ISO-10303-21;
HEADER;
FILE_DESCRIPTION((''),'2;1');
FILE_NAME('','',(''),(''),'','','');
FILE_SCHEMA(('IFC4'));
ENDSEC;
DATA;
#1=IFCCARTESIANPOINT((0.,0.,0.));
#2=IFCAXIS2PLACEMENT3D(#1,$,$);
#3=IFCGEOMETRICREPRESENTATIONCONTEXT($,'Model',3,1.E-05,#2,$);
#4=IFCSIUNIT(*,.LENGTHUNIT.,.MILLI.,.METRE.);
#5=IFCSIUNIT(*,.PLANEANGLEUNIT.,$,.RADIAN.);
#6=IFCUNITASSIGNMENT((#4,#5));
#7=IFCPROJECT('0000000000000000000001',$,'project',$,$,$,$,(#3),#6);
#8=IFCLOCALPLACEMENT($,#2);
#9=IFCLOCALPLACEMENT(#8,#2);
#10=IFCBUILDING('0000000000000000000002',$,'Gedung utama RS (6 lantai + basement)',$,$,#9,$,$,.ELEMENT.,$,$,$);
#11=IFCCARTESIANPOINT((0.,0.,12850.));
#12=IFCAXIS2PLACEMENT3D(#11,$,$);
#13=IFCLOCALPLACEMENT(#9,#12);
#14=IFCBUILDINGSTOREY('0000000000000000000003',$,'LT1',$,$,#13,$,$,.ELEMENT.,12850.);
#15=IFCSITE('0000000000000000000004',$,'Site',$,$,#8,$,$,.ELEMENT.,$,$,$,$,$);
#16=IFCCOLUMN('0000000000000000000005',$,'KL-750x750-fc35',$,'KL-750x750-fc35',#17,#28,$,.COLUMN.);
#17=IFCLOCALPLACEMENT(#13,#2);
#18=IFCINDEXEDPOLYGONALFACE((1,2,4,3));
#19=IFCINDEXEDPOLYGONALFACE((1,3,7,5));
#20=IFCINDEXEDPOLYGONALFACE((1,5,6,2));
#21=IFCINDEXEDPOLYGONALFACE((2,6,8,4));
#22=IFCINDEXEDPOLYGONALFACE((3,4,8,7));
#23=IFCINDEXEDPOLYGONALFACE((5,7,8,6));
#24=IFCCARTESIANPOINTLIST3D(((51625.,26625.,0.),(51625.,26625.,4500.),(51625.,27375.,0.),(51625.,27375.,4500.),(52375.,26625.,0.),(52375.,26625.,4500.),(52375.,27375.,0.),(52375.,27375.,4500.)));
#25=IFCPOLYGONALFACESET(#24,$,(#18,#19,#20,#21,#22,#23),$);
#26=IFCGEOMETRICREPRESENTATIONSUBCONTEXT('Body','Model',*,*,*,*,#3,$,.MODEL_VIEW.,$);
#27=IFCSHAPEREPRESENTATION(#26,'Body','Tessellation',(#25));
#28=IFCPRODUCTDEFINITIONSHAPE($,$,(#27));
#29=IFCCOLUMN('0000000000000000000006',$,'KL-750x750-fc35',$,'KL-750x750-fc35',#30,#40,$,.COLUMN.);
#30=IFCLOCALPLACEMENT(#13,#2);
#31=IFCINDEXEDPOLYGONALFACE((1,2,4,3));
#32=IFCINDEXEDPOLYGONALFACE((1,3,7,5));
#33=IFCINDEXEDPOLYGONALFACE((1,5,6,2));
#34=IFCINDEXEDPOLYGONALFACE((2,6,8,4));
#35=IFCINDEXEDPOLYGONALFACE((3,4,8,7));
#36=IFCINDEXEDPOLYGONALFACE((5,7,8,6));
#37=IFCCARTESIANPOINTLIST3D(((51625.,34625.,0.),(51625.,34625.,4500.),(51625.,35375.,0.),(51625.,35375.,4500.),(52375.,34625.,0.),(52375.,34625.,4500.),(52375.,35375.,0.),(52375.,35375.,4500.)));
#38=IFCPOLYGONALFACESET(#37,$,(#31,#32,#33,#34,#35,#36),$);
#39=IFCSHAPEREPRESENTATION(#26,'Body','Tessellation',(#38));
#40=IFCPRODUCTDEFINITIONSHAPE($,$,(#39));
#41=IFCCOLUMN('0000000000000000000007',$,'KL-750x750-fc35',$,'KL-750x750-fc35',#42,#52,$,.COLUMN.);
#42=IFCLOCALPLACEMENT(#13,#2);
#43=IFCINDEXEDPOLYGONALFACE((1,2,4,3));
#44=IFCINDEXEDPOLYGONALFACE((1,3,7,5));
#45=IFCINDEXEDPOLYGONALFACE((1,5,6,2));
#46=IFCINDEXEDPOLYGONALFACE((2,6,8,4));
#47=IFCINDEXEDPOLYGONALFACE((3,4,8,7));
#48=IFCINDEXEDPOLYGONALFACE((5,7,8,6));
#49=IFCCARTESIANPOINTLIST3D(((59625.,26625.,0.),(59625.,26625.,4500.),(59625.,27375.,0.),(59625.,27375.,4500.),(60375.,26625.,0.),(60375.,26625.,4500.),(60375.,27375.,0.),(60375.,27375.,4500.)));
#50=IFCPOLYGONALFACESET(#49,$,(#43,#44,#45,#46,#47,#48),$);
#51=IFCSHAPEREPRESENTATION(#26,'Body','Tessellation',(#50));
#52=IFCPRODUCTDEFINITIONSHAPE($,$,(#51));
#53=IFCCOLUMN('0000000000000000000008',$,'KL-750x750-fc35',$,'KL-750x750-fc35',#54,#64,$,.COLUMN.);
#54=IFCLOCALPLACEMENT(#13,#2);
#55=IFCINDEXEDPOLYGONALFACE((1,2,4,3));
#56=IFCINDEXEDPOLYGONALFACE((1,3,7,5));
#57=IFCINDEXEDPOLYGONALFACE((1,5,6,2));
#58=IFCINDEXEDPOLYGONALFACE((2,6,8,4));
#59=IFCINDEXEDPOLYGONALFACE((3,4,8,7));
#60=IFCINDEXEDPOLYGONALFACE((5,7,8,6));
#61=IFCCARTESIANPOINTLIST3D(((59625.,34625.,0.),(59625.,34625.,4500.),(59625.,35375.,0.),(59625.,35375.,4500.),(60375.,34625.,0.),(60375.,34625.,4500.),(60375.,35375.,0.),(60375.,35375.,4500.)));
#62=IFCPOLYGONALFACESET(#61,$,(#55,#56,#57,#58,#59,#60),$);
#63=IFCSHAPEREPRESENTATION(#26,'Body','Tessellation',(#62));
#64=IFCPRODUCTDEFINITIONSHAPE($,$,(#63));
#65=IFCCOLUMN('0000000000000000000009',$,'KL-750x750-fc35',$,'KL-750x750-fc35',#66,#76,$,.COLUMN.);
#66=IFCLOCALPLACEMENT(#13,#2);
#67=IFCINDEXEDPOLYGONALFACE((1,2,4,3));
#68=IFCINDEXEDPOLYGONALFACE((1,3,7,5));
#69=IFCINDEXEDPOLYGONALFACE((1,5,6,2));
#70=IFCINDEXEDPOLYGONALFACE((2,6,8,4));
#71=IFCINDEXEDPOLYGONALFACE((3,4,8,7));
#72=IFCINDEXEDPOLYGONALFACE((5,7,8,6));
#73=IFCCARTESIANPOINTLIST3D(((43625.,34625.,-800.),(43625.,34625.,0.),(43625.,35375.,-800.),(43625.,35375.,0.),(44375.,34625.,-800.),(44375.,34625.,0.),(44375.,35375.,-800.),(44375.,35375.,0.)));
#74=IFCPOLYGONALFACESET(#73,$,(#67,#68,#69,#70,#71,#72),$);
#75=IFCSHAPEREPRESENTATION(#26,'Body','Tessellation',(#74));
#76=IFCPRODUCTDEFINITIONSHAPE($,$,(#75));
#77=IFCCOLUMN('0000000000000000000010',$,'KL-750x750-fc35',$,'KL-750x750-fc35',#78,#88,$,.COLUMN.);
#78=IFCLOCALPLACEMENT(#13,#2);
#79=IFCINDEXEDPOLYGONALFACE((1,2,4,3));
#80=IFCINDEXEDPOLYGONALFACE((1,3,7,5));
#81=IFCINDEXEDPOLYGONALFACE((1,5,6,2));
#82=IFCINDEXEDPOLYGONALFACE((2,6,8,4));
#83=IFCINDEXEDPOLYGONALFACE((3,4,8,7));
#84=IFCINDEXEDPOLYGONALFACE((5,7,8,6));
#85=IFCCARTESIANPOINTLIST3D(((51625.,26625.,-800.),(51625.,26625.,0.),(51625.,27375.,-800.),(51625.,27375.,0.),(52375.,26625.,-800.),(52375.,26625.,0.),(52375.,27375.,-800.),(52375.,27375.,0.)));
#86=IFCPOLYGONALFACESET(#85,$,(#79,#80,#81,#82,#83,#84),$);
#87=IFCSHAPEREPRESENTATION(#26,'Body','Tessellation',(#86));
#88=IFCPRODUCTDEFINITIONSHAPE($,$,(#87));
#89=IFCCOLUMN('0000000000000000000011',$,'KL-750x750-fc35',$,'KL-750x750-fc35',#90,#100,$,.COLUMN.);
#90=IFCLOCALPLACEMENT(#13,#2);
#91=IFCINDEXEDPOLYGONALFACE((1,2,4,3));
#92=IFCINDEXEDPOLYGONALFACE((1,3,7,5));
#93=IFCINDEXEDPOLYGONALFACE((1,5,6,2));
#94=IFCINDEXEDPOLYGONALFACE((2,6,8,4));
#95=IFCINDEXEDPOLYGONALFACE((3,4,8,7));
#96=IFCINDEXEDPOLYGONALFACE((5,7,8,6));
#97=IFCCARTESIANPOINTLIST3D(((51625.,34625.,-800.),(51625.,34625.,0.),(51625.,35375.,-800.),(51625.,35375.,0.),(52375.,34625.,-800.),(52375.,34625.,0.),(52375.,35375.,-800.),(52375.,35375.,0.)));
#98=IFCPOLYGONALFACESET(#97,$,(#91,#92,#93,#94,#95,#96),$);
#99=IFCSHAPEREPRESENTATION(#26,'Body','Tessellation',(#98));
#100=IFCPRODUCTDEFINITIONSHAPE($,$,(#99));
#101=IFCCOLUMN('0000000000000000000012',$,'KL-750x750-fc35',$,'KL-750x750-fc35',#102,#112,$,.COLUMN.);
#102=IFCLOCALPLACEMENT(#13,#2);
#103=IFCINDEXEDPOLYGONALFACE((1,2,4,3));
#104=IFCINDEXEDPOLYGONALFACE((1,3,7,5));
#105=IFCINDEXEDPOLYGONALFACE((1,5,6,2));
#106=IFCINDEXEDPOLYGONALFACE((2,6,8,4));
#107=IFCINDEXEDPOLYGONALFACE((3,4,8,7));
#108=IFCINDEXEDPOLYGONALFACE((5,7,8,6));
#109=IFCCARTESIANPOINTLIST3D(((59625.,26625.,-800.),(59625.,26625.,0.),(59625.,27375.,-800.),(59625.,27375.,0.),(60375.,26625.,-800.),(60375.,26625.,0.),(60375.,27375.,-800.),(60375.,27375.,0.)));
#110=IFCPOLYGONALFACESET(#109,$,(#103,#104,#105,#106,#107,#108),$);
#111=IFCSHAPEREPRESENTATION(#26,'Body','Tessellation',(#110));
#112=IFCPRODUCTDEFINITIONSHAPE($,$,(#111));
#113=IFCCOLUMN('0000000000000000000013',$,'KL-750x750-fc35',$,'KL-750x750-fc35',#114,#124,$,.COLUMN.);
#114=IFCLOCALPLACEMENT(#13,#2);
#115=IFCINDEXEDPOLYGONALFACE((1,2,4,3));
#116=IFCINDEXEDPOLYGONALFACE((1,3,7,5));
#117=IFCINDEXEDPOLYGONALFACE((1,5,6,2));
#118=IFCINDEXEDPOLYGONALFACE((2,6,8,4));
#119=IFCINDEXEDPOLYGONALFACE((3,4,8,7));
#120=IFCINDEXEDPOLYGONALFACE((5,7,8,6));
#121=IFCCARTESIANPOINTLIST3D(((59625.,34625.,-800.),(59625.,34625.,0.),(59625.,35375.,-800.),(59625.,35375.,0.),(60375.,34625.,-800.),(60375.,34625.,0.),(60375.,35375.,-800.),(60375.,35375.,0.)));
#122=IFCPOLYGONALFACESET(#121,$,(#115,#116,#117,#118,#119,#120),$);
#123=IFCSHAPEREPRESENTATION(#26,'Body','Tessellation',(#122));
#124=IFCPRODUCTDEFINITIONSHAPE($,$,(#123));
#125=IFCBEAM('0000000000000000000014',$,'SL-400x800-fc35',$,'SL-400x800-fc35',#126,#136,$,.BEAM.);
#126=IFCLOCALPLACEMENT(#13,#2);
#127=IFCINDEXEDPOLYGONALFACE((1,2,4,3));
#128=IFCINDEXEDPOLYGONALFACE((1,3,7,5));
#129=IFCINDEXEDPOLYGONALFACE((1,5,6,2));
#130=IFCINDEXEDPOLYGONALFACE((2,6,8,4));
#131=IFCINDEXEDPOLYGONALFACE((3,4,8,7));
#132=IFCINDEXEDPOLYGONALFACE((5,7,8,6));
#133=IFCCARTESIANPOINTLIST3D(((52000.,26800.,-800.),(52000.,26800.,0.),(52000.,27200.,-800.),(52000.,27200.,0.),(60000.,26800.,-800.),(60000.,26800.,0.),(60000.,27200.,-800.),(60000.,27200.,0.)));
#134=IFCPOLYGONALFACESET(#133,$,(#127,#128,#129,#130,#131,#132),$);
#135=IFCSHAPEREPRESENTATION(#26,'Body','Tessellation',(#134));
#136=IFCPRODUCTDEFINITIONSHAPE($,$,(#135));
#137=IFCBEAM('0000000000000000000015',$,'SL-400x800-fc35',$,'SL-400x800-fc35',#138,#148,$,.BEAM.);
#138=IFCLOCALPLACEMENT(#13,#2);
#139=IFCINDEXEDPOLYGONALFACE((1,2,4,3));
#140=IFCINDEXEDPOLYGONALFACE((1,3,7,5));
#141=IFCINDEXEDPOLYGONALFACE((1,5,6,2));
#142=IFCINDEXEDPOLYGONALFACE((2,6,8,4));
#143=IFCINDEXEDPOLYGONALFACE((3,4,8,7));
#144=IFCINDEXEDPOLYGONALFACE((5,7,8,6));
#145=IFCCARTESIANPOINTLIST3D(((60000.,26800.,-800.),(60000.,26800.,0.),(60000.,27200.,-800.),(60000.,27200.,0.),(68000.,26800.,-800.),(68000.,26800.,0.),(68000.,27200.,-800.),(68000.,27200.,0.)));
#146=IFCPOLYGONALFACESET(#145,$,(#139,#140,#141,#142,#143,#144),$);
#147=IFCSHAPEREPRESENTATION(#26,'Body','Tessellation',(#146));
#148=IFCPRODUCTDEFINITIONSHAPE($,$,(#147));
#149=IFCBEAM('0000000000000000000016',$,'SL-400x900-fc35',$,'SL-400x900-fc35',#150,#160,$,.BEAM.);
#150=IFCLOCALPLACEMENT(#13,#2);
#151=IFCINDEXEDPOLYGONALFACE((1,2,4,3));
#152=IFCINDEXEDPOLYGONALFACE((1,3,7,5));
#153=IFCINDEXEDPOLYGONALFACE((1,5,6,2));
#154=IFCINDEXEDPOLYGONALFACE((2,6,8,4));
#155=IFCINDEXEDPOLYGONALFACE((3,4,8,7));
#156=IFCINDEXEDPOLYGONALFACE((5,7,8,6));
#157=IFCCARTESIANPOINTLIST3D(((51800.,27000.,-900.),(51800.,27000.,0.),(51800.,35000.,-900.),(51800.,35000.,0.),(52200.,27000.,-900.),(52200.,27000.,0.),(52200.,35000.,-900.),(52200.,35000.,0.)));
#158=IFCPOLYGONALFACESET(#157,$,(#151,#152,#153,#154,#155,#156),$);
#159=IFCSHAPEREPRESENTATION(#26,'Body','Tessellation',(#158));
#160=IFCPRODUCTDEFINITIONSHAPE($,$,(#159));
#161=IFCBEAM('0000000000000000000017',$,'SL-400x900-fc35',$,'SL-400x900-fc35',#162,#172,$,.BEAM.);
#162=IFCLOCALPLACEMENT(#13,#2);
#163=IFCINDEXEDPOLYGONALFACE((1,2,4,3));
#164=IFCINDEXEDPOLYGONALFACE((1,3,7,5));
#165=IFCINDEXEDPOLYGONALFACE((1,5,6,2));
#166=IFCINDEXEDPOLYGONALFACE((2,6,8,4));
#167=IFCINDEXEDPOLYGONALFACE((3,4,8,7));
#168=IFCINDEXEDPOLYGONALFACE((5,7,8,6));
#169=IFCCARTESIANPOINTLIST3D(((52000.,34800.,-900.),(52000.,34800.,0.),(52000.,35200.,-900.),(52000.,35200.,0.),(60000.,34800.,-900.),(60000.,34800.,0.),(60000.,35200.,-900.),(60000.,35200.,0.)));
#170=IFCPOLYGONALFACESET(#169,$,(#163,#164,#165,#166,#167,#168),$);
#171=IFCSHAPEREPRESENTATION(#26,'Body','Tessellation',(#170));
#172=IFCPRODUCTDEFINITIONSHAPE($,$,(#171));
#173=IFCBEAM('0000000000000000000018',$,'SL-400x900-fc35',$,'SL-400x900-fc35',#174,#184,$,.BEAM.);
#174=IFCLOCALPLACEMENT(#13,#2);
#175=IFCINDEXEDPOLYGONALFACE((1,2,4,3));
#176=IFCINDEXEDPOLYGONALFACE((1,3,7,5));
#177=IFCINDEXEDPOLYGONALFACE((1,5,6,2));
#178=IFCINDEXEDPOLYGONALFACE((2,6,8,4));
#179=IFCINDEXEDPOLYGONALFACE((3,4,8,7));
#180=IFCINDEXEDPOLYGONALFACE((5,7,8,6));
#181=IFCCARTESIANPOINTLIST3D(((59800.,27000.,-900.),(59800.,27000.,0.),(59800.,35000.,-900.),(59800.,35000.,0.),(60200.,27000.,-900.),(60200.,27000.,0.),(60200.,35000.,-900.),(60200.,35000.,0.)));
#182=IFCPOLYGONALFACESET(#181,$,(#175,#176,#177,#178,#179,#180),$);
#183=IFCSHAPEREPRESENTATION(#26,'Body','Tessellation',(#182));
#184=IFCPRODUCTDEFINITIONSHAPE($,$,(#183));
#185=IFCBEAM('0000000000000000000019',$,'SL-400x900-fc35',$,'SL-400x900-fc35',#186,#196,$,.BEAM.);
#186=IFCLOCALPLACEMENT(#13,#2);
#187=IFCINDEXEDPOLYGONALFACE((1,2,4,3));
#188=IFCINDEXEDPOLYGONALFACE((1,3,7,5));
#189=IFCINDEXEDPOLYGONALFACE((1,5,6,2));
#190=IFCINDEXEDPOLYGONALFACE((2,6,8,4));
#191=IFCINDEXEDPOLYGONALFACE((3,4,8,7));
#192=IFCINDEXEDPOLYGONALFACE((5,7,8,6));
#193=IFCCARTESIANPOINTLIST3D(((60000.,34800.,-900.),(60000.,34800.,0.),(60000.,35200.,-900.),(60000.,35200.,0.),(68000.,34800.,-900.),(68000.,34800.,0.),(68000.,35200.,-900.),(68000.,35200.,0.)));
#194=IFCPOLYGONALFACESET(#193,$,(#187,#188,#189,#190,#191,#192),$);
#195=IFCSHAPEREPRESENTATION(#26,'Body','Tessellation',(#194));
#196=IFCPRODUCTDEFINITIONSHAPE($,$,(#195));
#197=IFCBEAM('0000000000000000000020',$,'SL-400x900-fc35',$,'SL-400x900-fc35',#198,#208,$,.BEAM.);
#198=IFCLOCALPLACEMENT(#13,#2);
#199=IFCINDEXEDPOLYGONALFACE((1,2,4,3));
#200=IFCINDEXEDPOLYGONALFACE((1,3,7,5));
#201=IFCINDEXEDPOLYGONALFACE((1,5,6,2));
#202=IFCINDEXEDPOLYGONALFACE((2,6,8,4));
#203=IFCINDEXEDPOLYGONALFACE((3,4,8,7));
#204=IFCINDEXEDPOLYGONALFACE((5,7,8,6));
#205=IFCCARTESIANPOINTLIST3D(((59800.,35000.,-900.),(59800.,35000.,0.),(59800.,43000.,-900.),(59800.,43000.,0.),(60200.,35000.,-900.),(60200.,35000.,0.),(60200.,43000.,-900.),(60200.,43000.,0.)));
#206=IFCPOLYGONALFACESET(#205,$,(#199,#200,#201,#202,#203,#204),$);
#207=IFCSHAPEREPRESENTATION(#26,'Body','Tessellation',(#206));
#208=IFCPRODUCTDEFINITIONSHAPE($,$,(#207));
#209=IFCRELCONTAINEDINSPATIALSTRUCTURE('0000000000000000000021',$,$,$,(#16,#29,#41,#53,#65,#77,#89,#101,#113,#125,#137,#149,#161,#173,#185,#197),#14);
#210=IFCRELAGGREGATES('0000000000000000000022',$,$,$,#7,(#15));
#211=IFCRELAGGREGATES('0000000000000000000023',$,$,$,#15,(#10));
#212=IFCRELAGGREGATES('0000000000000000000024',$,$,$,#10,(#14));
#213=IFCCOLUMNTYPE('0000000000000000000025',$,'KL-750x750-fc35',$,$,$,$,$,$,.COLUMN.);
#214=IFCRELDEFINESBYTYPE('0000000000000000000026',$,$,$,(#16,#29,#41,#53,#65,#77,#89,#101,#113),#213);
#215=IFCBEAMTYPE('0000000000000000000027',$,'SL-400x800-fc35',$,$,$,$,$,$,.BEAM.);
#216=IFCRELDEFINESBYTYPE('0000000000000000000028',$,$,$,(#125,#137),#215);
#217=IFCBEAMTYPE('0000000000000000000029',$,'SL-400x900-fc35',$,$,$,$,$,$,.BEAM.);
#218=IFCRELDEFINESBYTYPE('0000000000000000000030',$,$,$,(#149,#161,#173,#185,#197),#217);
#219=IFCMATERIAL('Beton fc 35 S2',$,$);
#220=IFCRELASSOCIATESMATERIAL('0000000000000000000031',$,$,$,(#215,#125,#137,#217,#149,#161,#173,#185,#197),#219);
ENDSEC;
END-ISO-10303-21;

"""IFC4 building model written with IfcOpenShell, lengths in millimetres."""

from ifc_helpers import new_model, si_unit, frame, origin, origin_2d, place, context, subcontext, project, spatial, rectangle, extrude, material, material_profile, profile_set, profile_usage, type_object, element, save


model = new_model("IFC4")

# Units and contexts
model_context = context("Model", 3, precision=1e-05, world=origin())
body_context = subcontext(model_context, "Body", "Model", "MODEL_VIEW")
ifc_project = project(units=[si_unit("LENGTHUNIT", "METRE", prefix="MILLI"), si_unit("PLANEANGLEUNIT", "RADIAN")], contexts=[model_context])

# Site, building, storey
site_placement = place(None, origin())
site = spatial("IfcSite", under=ifc_project, at=site_placement, Name="Site", CompositionType="ELEMENT")
building_placement = place(site_placement, origin())
building = spatial("IfcBuilding", under=site, at=building_placement, Name="Gedung utama RS (6 lantai + basement)", CompositionType="ELEMENT")
storey_placement = place(building_placement, frame((0.0, 0.0, 12850.0)))
storey = spatial("IfcBuildingStorey", under=building, at=storey_placement, Name="LT1", CompositionType="ELEMENT", Elevation=12850.0)

# Columns
ifc_material_profile_1 = material_profile(None, rectangle(XDim=750.0, YDim=750.0, at=origin_2d()), Name="KL-750x750-fc35")
ifc_profile_set_1 = profile_set([ifc_material_profile_1], Name="KL-750x750-fc35")
ifc_profile_usage_1 = profile_usage(ifc_profile_set_1, cardinal=5)
column_type = type_object("IfcColumnType", Name="KL-750x750-fc35", PredefinedType="COLUMN", material=ifc_profile_set_1)
for number, where, z_axis, x_axis, name in (
    (1, (52000.0, 27000.0, 0.0), (0.0, 0.0, 1.0), (1.0, 0.0, 0.0), "KL-750x750-fc35"),
    (2, (52000.0, 35000.0, 0.0), (0.0, 0.0, 1.0), (1.0, 0.0, 0.0), "KL-750x750-fc35"),
    (3, (60000.0, 27000.0, 0.0), (0.0, 0.0, 1.0), (1.0, 0.0, 0.0), "KL-750x750-fc35"),
    (4, (60000.0, 35000.0, 0.0), (0.0, 0.0, 1.0), (1.0, 0.0, 0.0), "KL-750x750-fc35"),
):
    element("IfcColumn", number, at=place(storey_placement, frame(where, z_axis=z_axis, x_axis=x_axis)), inside=storey, type_object=column_type, material=ifc_profile_usage_1, Name=name, ObjectType="KL-750x750-fc35", PredefinedType="COLUMN", context=body_context, shape_type="SweptSolid", body=[
        extrude(rectangle(XDim=750.0, YDim=750.0, at=origin_2d()), origin(), (0.0, 0.0, 1.0), 4500.0),
    ])
for number, where, z_axis, x_axis, name in (
    (5, (44000.0, 35000.0, -800.0), (0.0, 0.0, 1.0), (1.0, 0.0, 0.0), "KL-750x750-fc35"),
    (6, (52000.0, 27000.0, -800.0), (0.0, 0.0, 1.0), (1.0, 0.0, 0.0), "KL-750x750-fc35"),
    (7, (52000.0, 35000.0, -800.0), (0.0, 0.0, 1.0), (1.0, 0.0, 0.0), "KL-750x750-fc35"),
    (8, (60000.0, 27000.0, -800.0), (0.0, 0.0, 1.0), (1.0, 0.0, 0.0), "KL-750x750-fc35"),
    (9, (60000.0, 35000.0, -800.0), (0.0, 0.0, 1.0), (1.0, 0.0, 0.0), "KL-750x750-fc35"),
):
    element("IfcColumn", number, at=place(storey_placement, frame(where, z_axis=z_axis, x_axis=x_axis)), inside=storey, type_object=column_type, material=ifc_profile_usage_1, Name=name, ObjectType="KL-750x750-fc35", PredefinedType="COLUMN", context=body_context, shape_type="SweptSolid", body=[
        extrude(rectangle(XDim=750.0, YDim=750.0, at=origin_2d()), origin(), (0.0, 0.0, 1.0), 800.0),
    ])

# Beams
ifc_material = material(Name="Beton fc 35 S2")
ifc_material_profile_2 = material_profile(ifc_material, rectangle(XDim=400.0, YDim=800.0, at=origin_2d()), Name="SL-400x800-fc35")
ifc_profile_set_2 = profile_set([ifc_material_profile_2], Name="SL-400x800-fc35")
ifc_profile_usage_2 = profile_usage(ifc_profile_set_2, cardinal=8)
beam_type_1 = type_object("IfcBeamType", Name="SL-400x800-fc35", PredefinedType="BEAM", material=ifc_profile_set_2)
for number, where, name in (
    (10, (52000.0, 27000.0, -400.0), "SL-400x800-fc35"),
    (11, (60000.0, 27000.0, -400.0), "SL-400x800-fc35"),
):
    element("IfcBeam", number, at=place(storey_placement, frame(where)), inside=storey, type_object=beam_type_1, material=ifc_profile_usage_2, Name=name, ObjectType="SL-400x800-fc35", PredefinedType="BEAM", context=body_context, shape_type="SweptSolid", body=[
        extrude(rectangle(XDim=400.0, YDim=800.0, at=origin_2d()), frame((0.0, 0.0, 0.0), z_axis=(1.0, 0.0, 0.0), x_axis=(0.0, 1.0, 0.0)), (0.0, 0.0, 1.0), 8000.0),
    ])
ifc_material_profile_3 = material_profile(ifc_material, rectangle(XDim=400.0, YDim=900.0, at=origin_2d()), Name="SL-400x900-fc35")
ifc_profile_set_3 = profile_set([ifc_material_profile_3], Name="SL-400x900-fc35")
ifc_profile_usage_3 = profile_usage(ifc_profile_set_3, cardinal=8)
beam_type_2 = type_object("IfcBeamType", Name="SL-400x900-fc35", PredefinedType="BEAM", material=ifc_profile_set_3)
beam_1_placement = place(storey_placement, frame((52000.0, 27000.0, -450.0)))
element("IfcBeam", 12, at=beam_1_placement, inside=storey, type_object=beam_type_2, material=ifc_profile_usage_3, Name="SL-400x900-fc35", ObjectType="SL-400x900-fc35", PredefinedType="BEAM", context=body_context, shape_type="SweptSolid", body=[
    extrude(rectangle(XDim=400.0, YDim=900.0, at=origin_2d()), frame((0.0, 0.0, 0.0), z_axis=(0.0, 1.0, 0.0), x_axis=(-1.0, 0.0, 0.0)), (0.0, 0.0, 1.0), 8000.0),
])
beam_2_placement = place(storey_placement, frame((52000.0, 35000.0, -450.0)))
element("IfcBeam", 13, at=beam_2_placement, inside=storey, type_object=beam_type_2, material=ifc_profile_usage_3, Name="SL-400x900-fc35", ObjectType="SL-400x900-fc35", PredefinedType="BEAM", context=body_context, shape_type="SweptSolid", body=[
    extrude(rectangle(XDim=400.0, YDim=900.0, at=origin_2d()), frame((0.0, 0.0, 0.0), z_axis=(1.0, 0.0, 0.0), x_axis=(0.0, 1.0, 0.0)), (0.0, 0.0, 1.0), 8000.0),
])
beam_3_placement = place(storey_placement, frame((60000.0, 27000.0, -450.0)))
element("IfcBeam", 14, at=beam_3_placement, inside=storey, type_object=beam_type_2, material=ifc_profile_usage_3, Name="SL-400x900-fc35", ObjectType="SL-400x900-fc35", PredefinedType="BEAM", context=body_context, shape_type="SweptSolid", body=[
    extrude(rectangle(XDim=400.0, YDim=900.0, at=origin_2d()), frame((0.0, 0.0, 0.0), z_axis=(0.0, 1.0, 0.0), x_axis=(-1.0, 0.0, 0.0)), (0.0, 0.0, 1.0), 8000.0),
])
beam_4_placement = place(storey_placement, frame((60000.0, 35000.0, -450.0)))
element("IfcBeam", 15, at=beam_4_placement, inside=storey, type_object=beam_type_2, material=ifc_profile_usage_3, Name="SL-400x900-fc35", ObjectType="SL-400x900-fc35", PredefinedType="BEAM", context=body_context, shape_type="SweptSolid", body=[
    extrude(rectangle(XDim=400.0, YDim=900.0, at=origin_2d()), frame((0.0, 0.0, 0.0), z_axis=(1.0, 0.0, 0.0), x_axis=(0.0, 1.0, 0.0)), (0.0, 0.0, 1.0), 8000.0),
])
beam_5_placement = place(storey_placement, frame((60000.0, 35000.0, -450.0)))
element("IfcBeam", 16, at=beam_5_placement, inside=storey, type_object=beam_type_2, material=ifc_profile_usage_3, Name="SL-400x900-fc35", ObjectType="SL-400x900-fc35", PredefinedType="BEAM", context=body_context, shape_type="SweptSolid", body=[
    extrude(rectangle(XDim=400.0, YDim=900.0, at=origin_2d()), frame((0.0, 0.0, 0.0), z_axis=(0.0, 1.0, 0.0), x_axis=(-1.0, 0.0, 0.0)), (0.0, 0.0, 1.0), 8000.0),
])

save(model, "model.ifc")
